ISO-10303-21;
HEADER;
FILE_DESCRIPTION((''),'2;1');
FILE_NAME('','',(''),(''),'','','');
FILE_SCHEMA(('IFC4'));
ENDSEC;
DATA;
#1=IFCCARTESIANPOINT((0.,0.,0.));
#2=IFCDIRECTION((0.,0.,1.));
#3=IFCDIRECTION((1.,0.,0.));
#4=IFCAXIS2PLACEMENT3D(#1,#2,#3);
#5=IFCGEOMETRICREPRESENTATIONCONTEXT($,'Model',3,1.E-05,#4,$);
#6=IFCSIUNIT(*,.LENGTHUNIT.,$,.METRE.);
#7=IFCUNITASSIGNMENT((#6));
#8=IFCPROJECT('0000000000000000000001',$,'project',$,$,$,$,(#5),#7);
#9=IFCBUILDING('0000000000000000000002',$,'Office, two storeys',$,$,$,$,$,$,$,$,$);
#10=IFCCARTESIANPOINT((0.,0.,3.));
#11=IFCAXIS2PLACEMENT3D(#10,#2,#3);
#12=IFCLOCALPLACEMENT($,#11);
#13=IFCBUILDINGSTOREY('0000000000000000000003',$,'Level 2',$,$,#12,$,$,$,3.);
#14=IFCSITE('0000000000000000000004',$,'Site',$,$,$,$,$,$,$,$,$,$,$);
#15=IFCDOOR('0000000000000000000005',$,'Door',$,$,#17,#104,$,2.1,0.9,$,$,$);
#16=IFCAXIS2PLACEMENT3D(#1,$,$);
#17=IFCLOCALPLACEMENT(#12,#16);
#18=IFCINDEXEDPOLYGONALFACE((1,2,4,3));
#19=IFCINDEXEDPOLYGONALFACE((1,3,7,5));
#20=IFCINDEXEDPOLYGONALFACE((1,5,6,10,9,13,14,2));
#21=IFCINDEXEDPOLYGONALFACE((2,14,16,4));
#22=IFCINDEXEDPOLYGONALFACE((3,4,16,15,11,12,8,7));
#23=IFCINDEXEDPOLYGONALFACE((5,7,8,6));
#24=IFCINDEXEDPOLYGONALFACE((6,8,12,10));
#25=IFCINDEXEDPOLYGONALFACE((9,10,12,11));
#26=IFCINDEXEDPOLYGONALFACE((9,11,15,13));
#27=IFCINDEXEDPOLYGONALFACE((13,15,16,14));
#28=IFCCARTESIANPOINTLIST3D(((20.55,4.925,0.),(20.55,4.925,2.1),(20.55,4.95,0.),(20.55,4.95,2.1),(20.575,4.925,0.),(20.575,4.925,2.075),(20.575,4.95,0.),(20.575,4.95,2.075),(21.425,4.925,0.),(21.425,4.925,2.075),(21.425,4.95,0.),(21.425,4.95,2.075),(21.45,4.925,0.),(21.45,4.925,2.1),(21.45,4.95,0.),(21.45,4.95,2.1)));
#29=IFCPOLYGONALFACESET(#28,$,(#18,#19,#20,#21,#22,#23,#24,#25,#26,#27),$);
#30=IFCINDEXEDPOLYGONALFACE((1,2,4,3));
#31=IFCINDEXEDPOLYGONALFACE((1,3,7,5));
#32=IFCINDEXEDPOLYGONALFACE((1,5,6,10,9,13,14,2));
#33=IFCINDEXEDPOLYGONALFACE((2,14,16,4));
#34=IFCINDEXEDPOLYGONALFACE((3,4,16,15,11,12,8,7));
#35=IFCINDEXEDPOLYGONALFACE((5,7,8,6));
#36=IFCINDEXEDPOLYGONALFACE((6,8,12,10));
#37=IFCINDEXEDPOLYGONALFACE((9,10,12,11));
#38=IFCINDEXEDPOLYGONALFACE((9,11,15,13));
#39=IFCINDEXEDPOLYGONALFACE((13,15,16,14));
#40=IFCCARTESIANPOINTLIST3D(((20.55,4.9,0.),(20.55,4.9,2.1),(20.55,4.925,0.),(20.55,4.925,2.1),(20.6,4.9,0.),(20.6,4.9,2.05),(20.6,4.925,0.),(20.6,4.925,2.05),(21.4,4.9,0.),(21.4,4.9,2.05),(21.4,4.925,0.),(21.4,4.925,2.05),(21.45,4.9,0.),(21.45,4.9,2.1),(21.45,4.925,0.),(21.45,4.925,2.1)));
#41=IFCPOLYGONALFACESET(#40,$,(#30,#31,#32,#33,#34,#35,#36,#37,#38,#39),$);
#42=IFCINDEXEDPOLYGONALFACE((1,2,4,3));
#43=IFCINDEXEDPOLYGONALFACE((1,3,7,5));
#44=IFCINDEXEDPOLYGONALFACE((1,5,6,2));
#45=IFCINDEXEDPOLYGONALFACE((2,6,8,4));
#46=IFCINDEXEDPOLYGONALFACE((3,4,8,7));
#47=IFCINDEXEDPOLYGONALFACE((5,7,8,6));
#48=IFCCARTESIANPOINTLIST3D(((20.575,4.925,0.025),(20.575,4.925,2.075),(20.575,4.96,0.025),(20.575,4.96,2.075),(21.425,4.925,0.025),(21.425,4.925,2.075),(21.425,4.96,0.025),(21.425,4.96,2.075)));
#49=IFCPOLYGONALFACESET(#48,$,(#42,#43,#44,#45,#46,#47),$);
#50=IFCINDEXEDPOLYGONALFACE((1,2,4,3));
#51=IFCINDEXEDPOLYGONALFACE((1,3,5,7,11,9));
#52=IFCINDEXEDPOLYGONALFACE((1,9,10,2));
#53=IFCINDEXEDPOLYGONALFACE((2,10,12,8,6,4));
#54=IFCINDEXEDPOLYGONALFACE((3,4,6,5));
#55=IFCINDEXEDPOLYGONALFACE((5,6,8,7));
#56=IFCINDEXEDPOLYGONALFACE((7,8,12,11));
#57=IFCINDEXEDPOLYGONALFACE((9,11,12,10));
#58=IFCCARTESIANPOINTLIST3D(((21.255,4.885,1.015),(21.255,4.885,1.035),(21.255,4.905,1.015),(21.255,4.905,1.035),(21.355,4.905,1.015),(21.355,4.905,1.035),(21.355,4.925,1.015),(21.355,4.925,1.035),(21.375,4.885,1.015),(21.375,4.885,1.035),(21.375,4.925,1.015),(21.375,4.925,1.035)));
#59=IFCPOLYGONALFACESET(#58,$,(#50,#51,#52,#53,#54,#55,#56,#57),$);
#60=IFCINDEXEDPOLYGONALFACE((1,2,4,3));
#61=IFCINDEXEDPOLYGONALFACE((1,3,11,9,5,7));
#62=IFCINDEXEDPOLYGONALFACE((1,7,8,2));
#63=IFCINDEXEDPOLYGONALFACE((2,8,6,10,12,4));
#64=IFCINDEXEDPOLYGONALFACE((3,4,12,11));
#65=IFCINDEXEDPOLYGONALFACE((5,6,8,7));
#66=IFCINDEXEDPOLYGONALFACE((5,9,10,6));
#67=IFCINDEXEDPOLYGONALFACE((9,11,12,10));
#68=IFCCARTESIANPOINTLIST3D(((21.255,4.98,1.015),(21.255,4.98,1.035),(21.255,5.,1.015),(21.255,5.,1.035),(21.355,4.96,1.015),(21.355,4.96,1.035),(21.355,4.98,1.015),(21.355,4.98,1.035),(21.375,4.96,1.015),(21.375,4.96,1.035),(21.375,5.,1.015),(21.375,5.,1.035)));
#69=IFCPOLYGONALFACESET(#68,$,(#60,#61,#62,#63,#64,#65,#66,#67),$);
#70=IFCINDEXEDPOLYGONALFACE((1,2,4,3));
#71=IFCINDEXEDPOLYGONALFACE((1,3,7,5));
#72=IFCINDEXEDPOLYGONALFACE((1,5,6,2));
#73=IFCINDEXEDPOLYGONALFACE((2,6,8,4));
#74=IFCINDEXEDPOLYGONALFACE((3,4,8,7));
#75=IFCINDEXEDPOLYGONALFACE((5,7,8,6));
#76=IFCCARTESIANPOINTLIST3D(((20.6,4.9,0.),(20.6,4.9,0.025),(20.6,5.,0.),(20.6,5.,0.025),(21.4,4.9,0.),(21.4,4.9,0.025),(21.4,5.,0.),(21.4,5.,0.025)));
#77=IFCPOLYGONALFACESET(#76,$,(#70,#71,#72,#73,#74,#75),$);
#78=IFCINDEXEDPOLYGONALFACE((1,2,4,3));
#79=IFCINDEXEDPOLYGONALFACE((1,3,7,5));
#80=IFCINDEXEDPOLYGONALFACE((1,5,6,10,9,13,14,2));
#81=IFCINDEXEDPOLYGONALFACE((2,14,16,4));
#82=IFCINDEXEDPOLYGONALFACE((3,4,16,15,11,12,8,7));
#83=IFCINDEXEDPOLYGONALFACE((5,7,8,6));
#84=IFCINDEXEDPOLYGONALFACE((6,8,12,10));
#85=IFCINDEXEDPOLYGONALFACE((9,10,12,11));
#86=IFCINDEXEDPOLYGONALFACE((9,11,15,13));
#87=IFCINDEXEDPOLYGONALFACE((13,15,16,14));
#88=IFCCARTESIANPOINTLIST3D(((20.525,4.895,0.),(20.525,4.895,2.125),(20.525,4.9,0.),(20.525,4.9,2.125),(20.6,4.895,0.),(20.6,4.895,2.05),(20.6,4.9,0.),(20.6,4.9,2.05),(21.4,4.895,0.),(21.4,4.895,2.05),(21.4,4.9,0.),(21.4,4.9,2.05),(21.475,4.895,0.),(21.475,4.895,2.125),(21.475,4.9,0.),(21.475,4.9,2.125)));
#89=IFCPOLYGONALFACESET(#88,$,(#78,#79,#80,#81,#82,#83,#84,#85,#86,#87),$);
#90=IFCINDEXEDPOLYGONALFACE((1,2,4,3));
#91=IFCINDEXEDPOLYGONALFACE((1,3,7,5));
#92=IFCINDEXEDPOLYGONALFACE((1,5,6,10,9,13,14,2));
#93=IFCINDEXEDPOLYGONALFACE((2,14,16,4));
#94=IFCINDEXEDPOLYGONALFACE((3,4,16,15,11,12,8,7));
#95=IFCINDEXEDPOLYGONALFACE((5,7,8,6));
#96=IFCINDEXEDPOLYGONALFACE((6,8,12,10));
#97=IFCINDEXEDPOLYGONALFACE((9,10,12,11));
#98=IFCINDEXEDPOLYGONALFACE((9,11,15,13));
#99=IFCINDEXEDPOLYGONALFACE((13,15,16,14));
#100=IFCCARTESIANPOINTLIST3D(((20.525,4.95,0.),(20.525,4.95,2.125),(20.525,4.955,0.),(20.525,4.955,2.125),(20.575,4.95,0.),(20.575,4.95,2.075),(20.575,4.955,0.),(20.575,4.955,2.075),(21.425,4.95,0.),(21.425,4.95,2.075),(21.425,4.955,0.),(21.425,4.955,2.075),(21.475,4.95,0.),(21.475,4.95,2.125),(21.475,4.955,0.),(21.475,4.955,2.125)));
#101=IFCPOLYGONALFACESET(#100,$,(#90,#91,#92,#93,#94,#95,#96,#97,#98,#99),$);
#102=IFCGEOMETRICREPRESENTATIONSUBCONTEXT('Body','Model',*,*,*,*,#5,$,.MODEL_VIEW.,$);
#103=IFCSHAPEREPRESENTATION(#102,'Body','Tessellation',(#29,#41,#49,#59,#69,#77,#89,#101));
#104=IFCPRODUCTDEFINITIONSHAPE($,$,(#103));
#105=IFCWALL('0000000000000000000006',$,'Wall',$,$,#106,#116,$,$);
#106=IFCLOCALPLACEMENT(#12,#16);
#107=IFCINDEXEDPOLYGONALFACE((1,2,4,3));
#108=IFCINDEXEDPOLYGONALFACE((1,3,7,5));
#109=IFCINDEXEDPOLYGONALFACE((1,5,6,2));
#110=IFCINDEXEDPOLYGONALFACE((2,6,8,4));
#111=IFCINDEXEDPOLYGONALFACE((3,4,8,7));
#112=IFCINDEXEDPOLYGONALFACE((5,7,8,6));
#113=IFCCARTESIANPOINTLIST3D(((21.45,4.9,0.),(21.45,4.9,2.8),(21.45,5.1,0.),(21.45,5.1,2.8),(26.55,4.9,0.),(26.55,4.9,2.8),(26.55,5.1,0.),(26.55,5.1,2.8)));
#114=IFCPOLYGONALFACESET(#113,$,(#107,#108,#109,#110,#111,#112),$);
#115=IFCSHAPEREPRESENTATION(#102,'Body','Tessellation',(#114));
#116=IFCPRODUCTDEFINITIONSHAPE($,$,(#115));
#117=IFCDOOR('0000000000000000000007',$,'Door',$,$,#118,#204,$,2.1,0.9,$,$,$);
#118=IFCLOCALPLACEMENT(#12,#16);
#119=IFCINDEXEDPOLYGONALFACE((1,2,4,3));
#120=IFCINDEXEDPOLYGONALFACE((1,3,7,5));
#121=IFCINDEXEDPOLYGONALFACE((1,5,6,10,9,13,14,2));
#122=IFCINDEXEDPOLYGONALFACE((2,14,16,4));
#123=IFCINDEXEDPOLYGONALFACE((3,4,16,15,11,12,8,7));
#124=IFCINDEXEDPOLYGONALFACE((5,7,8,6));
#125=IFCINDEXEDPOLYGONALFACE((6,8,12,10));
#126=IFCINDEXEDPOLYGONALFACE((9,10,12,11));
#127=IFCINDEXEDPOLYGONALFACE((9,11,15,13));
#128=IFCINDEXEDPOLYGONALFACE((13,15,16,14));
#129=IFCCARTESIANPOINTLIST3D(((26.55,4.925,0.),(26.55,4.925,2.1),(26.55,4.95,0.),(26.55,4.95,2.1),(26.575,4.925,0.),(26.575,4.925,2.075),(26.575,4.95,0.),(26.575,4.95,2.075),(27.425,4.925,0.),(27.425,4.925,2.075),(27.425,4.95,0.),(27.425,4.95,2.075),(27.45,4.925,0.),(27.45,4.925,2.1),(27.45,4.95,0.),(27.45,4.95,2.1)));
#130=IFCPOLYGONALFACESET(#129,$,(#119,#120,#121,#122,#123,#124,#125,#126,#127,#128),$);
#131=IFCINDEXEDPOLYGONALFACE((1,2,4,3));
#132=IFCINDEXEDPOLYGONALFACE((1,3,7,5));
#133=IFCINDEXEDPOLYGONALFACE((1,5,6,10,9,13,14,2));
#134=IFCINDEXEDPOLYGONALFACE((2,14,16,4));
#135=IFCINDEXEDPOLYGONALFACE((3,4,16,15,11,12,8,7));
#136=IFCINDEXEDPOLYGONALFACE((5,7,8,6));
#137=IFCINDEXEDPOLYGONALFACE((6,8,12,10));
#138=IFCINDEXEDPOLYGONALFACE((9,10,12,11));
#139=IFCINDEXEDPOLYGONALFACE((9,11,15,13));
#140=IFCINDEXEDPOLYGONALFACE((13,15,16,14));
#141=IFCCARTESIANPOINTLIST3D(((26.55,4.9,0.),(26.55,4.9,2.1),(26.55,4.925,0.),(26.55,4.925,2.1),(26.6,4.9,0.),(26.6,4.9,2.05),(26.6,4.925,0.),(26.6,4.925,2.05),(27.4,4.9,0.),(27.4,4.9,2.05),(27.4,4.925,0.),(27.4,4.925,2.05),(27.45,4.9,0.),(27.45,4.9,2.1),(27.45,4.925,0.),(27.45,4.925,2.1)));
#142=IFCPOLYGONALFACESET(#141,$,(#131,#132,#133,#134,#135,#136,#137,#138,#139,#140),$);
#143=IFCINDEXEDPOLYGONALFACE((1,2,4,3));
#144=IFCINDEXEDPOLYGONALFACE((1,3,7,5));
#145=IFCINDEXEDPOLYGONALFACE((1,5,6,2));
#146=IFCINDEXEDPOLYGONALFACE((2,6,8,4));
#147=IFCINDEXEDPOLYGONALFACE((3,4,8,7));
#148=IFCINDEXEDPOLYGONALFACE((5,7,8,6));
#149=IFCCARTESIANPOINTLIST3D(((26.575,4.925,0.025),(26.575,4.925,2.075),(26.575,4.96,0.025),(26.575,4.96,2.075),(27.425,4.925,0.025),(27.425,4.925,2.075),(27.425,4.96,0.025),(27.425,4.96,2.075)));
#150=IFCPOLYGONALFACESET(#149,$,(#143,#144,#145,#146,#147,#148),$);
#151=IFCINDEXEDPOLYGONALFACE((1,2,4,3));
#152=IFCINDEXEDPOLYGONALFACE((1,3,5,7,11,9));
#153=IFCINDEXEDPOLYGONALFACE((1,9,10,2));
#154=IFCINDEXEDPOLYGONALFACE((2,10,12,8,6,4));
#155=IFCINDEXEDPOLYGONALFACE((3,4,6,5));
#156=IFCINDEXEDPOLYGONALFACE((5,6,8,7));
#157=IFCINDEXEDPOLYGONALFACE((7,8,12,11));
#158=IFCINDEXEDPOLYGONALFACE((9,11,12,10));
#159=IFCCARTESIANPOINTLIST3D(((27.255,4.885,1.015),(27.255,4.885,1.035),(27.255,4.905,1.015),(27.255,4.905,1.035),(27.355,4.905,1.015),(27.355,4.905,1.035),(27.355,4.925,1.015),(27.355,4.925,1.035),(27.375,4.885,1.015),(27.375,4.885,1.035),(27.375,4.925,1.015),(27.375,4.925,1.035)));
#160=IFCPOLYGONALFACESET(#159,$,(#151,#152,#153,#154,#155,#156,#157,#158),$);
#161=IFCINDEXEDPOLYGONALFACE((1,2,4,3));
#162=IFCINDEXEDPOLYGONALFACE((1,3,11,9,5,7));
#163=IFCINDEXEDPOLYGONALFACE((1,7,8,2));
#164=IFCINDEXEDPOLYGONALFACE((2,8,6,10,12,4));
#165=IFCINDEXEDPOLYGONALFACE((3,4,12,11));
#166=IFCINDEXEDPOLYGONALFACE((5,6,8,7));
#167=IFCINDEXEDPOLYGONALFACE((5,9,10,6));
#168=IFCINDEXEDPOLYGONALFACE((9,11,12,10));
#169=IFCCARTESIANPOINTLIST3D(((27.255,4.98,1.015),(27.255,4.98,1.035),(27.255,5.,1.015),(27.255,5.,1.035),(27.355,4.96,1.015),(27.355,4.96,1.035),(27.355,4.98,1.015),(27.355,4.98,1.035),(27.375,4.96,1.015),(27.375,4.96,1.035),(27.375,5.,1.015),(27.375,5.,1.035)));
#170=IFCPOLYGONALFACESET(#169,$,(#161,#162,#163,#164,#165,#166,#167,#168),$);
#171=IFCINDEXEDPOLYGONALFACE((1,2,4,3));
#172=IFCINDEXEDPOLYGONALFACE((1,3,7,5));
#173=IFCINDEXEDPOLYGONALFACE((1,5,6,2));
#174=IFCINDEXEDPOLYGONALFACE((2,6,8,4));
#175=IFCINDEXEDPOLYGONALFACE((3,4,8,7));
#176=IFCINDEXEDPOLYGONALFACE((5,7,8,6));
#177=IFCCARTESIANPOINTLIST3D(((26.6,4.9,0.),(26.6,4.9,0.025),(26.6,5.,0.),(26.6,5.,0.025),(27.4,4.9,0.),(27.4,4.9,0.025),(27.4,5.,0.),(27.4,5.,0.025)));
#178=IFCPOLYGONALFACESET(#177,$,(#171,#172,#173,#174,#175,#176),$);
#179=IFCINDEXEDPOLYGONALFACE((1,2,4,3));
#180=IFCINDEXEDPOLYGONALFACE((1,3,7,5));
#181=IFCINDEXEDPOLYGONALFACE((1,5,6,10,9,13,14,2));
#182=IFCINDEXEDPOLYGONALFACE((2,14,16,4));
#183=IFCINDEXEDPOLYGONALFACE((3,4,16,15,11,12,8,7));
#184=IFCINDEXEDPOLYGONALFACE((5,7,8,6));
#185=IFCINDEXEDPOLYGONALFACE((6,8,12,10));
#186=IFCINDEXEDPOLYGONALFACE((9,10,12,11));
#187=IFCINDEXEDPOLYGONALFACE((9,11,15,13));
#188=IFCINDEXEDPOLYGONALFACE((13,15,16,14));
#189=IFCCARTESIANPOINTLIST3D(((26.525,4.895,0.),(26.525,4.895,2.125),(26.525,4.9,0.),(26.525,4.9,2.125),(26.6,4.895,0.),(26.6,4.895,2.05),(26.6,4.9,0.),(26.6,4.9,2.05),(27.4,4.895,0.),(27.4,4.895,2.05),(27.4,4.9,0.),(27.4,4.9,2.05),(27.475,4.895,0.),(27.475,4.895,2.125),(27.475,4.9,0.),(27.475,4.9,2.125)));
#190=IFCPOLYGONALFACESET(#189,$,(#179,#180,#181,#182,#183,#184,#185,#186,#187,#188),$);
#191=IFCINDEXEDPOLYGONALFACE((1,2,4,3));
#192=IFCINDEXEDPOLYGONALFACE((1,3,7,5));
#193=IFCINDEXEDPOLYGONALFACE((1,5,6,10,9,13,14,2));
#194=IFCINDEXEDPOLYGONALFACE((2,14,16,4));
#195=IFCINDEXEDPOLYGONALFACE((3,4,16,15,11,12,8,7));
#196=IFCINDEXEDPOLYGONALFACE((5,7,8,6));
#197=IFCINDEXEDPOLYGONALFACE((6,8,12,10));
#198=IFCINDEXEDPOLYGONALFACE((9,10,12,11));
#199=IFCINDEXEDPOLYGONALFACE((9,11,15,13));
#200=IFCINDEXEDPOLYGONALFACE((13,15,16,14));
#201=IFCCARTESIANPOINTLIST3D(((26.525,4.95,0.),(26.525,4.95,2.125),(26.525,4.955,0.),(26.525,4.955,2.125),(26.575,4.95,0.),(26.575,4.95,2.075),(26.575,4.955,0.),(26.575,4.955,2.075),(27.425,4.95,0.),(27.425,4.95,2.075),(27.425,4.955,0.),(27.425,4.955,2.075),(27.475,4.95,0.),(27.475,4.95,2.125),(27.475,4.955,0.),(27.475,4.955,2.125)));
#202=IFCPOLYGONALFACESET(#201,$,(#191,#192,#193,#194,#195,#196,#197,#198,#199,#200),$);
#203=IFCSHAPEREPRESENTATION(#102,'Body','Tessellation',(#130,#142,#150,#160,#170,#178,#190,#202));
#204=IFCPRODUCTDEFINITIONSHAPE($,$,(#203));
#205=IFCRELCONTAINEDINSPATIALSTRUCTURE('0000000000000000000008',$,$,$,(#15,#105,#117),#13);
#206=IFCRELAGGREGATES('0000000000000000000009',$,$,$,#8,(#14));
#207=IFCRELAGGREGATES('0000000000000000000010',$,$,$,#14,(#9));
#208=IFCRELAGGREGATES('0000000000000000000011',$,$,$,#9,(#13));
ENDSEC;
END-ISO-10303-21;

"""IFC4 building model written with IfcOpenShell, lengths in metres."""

from ifc_helpers import new_model, si_unit, frame, origin_with_axes, place, context, subcontext, project, spatial, line, indexed_curve, outline, extrude, element, save


model = new_model("IFC4")

# Units and contexts
model_context = context("Model", 3, precision=1e-05, world=origin_with_axes())
body_context = subcontext(model_context, "Body", "Model", "MODEL_VIEW")
ifc_project = project(units=[si_unit("LENGTHUNIT", "METRE")], contexts=[model_context])

# Site, building, storey
site = spatial("IfcSite", under=ifc_project, Name="Site")
building = spatial("IfcBuilding", under=site, Name="Office, two storeys")
storey_placement = place(None, frame((0.0, 0.0, 3.0), z_axis=(0.0, 0.0, 1.0), x_axis=(1.0, 0.0, 0.0)))
storey = spatial("IfcBuildingStorey", under=building, at=storey_placement, Name="Level 2", Elevation=3.0)

# Door
door_1_placement = place(storey_placement, frame((20.55, 4.9, 0.0), z_axis=(0.0, 0.0, 1.0), x_axis=(1.0, 0.0, 0.0)))
element("IfcDoor", 1, at=door_1_placement, inside=storey, Name="Door", OverallHeight=2.1, OverallWidth=0.9, context=body_context, shape_type="SweptSolid", body=[
    extrude(outline(indexed_curve([(0.0, 0.0), (0.0, 2.1), (0.9, 2.1), (0.9, 0.0), (0.875, 0.0), (0.875, 2.075), (0.025, 2.075), (0.025, 0.0)], segments=[line(1, 2, 3, 4, 5, 6, 7, 8, 1)])), frame((0.0, 0.025, 0.0), z_axis=(0.0, -1.0, 0.0), x_axis=(1.0, 0.0, 0.0)), (0.0, 0.0, -1.0), 0.025),
    extrude(outline(indexed_curve([(0.0, 0.0), (0.0, 2.1), (0.9, 2.1), (0.9, 0.0), (0.85, 0.0), (0.85, 2.05), (0.05, 2.05), (0.05, 0.0)], segments=[line(1, 2, 3, 4, 5, 6, 7, 8, 1)])), frame((0.0, 0.0, 0.0), z_axis=(0.0, -1.0, 0.0), x_axis=(1.0, 0.0, 0.0)), (0.0, 0.0, -1.0), 0.025),
    extrude(outline(indexed_curve([(0.0, 0.0), (0.85, 0.0), (0.85, 0.035), (0.0, 0.035)], segments=[line(1, 2, 3, 4, 1)])), frame((0.025, 0.025, 0.025), z_axis=(0.0, 0.0, 1.0), x_axis=(1.0, 0.0, 0.0)), (0.0, 0.0, 1.0), 2.05),
    extrude(outline(indexed_curve([(0.0, 0.0), (0.0, -0.04), (-0.12, -0.04), (-0.12, -0.02), (-0.02, -0.02), (-0.02, 0.0)], segments=[line(1, 2, 3, 4, 5, 6, 1)])), frame((0.825, 0.025, 1.015), z_axis=(0.0, 0.0, 1.0), x_axis=(1.0, 0.0, 0.0)), (0.0, 0.0, 1.0), 0.02),
    extrude(outline(indexed_curve([(0.0, 0.0), (0.0, 0.04), (-0.12, 0.04), (-0.12, 0.02), (-0.02, 0.02), (-0.02, 0.0)], segments=[line(1, 2, 3, 4, 5, 6, 1)])), frame((0.825, 0.06, 1.015), z_axis=(0.0, 0.0, 1.0), x_axis=(1.0, 0.0, 0.0)), (0.0, 0.0, 1.0), 0.02),
    extrude(outline(indexed_curve([(0.0, 0.0), (0.8, 0.0), (0.8, 0.1), (0.0, 0.1)], segments=[line(1, 2, 3, 4, 1)])), frame((0.05, 0.0, 0.0), z_axis=(0.0, 0.0, 1.0), x_axis=(1.0, 0.0, 0.0)), (0.0, 0.0, 1.0), 0.025),
    extrude(outline(indexed_curve([(0.0, 0.0), (0.0, 2.125), (0.95, 2.125), (0.95, 0.0), (0.875, 0.0), (0.875, 2.05), (0.075, 2.05), (0.075, 0.0)], segments=[line(1, 2, 3, 4, 5, 6, 7, 8, 1)])), frame((-0.025, -0.005, 0.0), z_axis=(0.0, -1.0, 0.0), x_axis=(1.0, 0.0, 0.0)), (0.0, 0.0, -1.0), 0.005),
    extrude(outline(indexed_curve([(0.0, 0.0), (0.0, 2.125), (0.95, 2.125), (0.95, 0.0), (0.9, 0.0), (0.9, 2.075), (0.05, 2.075), (0.05, 0.0)], segments=[line(1, 2, 3, 4, 5, 6, 7, 8, 1)])), frame((-0.025, 0.05, 0.0), z_axis=(0.0, -1.0, 0.0), x_axis=(1.0, 0.0, 0.0)), (0.0, 0.0, -1.0), 0.005),
])

# Wall
wall_1_placement = place(storey_placement, frame((21.45, 5.0, 0.0), z_axis=(0.0, 0.0, 1.0), x_axis=(1.0, 0.0, 0.0)))
element("IfcWall", 2, at=wall_1_placement, inside=storey, Name="Wall", context=body_context, shape_type="SweptSolid", body=[
    extrude(outline(indexed_curve([(0.0, 0.0), (0.0, 0.2), (5.1, 0.2), (5.1, 0.0), (0.0, 0.0)], self_intersect=False)), frame((0.0, -0.1, 0.0), z_axis=(0.0, 0.0, 1.0), x_axis=(1.0, 0.0, 0.0)), (0.0, 0.0, 1.0), 2.8),
])

# Door
door_2_placement = place(storey_placement, frame((26.55, 4.9, 0.0), z_axis=(0.0, 0.0, 1.0), x_axis=(1.0, 0.0, 0.0)))
element("IfcDoor", 3, at=door_2_placement, inside=storey, Name="Door", OverallHeight=2.1, OverallWidth=0.9, context=body_context, shape_type="SweptSolid", body=[
    extrude(outline(indexed_curve([(0.0, 0.0), (0.0, 2.1), (0.9, 2.1), (0.9, 0.0), (0.875, 0.0), (0.875, 2.075), (0.025, 2.075), (0.025, 0.0)], segments=[line(1, 2, 3, 4, 5, 6, 7, 8, 1)])), frame((0.0, 0.025, 0.0), z_axis=(0.0, -1.0, 0.0), x_axis=(1.0, 0.0, 0.0)), (0.0, 0.0, -1.0), 0.025),
    extrude(outline(indexed_curve([(0.0, 0.0), (0.0, 2.1), (0.9, 2.1), (0.9, 0.0), (0.85, 0.0), (0.85, 2.05), (0.05, 2.05), (0.05, 0.0)], segments=[line(1, 2, 3, 4, 5, 6, 7, 8, 1)])), frame((0.0, 0.0, 0.0), z_axis=(0.0, -1.0, 0.0), x_axis=(1.0, 0.0, 0.0)), (0.0, 0.0, -1.0), 0.025),
    extrude(outline(indexed_curve([(0.0, 0.0), (0.85, 0.0), (0.85, 0.035), (0.0, 0.035)], segments=[line(1, 2, 3, 4, 1)])), frame((0.025, 0.025, 0.025), z_axis=(0.0, 0.0, 1.0), x_axis=(1.0, 0.0, 0.0)), (0.0, 0.0, 1.0), 2.05),
    extrude(outline(indexed_curve([(0.0, 0.0), (0.0, -0.04), (-0.12, -0.04), (-0.12, -0.02), (-0.02, -0.02), (-0.02, 0.0)], segments=[line(1, 2, 3, 4, 5, 6, 1)])), frame((0.825, 0.025, 1.015), z_axis=(0.0, 0.0, 1.0), x_axis=(1.0, 0.0, 0.0)), (0.0, 0.0, 1.0), 0.02),
    extrude(outline(indexed_curve([(0.0, 0.0), (0.0, 0.04), (-0.12, 0.04), (-0.12, 0.02), (-0.02, 0.02), (-0.02, 0.0)], segments=[line(1, 2, 3, 4, 5, 6, 1)])), frame((0.825, 0.06, 1.015), z_axis=(0.0, 0.0, 1.0), x_axis=(1.0, 0.0, 0.0)), (0.0, 0.0, 1.0), 0.02),
    extrude(outline(indexed_curve([(0.0, 0.0), (0.8, 0.0), (0.8, 0.1), (0.0, 0.1)], segments=[line(1, 2, 3, 4, 1)])), frame((0.05, 0.0, 0.0), z_axis=(0.0, 0.0, 1.0), x_axis=(1.0, 0.0, 0.0)), (0.0, 0.0, 1.0), 0.025),
    extrude(outline(indexed_curve([(0.0, 0.0), (0.0, 2.125), (0.95, 2.125), (0.95, 0.0), (0.875, 0.0), (0.875, 2.05), (0.075, 2.05), (0.075, 0.0)], segments=[line(1, 2, 3, 4, 5, 6, 7, 8, 1)])), frame((-0.025, -0.005, 0.0), z_axis=(0.0, -1.0, 0.0), x_axis=(1.0, 0.0, 0.0)), (0.0, 0.0, -1.0), 0.005),
    extrude(outline(indexed_curve([(0.0, 0.0), (0.0, 2.125), (0.95, 2.125), (0.95, 0.0), (0.9, 0.0), (0.9, 2.075), (0.05, 2.075), (0.05, 0.0)], segments=[line(1, 2, 3, 4, 5, 6, 7, 8, 1)])), frame((-0.025, 0.05, 0.0), z_axis=(0.0, -1.0, 0.0), x_axis=(1.0, 0.0, 0.0)), (0.0, 0.0, -1.0), 0.005),
])

save(model, "model.ifc")
